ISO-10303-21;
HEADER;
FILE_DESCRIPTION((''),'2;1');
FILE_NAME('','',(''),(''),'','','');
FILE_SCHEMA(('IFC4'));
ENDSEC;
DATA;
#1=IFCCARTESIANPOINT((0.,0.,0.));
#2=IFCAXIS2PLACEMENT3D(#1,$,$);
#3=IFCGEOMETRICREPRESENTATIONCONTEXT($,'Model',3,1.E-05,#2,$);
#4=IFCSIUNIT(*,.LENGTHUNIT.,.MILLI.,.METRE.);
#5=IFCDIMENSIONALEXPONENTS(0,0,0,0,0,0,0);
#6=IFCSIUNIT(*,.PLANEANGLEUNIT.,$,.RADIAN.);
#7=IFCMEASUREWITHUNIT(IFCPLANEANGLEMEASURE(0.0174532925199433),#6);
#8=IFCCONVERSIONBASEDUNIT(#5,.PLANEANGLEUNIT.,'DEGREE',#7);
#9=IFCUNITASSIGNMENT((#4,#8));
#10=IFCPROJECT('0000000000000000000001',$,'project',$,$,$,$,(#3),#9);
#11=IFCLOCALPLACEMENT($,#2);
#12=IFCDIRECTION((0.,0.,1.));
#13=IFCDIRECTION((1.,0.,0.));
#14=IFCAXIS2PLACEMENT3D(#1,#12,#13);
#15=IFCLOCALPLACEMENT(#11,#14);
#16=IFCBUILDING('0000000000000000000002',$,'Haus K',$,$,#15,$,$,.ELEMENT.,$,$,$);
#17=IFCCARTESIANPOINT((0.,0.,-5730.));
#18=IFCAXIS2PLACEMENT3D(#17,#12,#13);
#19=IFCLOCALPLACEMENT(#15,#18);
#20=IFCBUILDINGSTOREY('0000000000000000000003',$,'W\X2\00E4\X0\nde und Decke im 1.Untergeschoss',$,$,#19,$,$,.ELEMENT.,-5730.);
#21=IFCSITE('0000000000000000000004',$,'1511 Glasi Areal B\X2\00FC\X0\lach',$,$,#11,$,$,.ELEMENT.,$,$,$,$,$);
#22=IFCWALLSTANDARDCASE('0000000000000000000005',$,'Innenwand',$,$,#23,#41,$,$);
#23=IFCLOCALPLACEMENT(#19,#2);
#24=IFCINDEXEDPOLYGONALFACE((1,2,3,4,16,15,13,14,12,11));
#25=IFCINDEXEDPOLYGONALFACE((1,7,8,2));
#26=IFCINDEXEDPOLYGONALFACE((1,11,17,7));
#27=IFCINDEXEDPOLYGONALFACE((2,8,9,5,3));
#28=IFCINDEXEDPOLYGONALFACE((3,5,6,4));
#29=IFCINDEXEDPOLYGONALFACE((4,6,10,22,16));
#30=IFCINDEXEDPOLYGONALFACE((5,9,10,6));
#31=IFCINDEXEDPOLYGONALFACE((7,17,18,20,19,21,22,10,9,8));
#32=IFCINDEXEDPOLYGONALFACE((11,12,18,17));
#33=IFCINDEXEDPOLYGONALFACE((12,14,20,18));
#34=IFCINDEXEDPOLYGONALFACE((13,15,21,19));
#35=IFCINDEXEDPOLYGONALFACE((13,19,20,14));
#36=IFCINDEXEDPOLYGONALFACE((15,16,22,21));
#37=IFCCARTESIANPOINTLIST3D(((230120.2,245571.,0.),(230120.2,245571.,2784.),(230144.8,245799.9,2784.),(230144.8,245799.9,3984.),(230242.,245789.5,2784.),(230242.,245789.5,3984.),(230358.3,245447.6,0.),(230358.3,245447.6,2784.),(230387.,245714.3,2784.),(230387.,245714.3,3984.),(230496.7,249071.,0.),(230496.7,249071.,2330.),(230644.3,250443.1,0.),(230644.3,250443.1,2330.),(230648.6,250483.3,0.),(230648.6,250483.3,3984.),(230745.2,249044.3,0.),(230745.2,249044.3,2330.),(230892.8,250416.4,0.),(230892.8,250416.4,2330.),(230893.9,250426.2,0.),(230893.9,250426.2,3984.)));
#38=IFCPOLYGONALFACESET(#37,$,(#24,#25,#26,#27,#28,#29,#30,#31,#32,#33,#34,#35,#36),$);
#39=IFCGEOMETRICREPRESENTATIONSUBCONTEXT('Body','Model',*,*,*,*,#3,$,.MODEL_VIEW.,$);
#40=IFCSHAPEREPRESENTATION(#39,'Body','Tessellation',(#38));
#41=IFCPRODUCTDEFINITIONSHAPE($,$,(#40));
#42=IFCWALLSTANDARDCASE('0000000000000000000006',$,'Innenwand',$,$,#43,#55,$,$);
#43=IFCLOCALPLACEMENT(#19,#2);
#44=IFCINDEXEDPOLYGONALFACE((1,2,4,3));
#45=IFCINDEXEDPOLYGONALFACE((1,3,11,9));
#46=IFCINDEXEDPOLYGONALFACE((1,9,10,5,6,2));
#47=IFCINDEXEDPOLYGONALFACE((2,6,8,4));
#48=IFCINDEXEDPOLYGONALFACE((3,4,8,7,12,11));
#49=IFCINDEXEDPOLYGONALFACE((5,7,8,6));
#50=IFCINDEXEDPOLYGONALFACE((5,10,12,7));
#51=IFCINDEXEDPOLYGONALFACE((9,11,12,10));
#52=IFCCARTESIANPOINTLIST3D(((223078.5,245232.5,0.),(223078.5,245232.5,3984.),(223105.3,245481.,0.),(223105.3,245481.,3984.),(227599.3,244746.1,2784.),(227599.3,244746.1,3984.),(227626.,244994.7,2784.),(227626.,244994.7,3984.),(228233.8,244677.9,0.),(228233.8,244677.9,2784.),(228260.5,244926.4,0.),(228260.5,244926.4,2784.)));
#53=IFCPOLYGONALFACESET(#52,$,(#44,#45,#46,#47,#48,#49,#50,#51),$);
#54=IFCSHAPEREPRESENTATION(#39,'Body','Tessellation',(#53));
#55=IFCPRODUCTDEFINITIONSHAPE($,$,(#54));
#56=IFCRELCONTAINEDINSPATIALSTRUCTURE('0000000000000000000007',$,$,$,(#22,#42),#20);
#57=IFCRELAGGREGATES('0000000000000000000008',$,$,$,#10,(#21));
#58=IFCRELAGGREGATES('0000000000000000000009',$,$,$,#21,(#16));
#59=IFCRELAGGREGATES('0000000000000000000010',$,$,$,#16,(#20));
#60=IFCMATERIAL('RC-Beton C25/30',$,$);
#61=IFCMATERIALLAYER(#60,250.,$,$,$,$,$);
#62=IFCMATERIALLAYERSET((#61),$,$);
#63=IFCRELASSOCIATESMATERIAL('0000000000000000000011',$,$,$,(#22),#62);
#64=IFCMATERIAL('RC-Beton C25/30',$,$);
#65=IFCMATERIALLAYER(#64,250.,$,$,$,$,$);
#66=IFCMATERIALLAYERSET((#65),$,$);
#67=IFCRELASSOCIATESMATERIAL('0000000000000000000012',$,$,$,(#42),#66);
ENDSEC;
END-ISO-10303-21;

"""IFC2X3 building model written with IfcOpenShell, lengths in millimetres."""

from ifc_helpers import new_model, entity, si_unit, converted_unit, frame, frame_2d, origin, origin_with_axes, place, context, subcontext, project, spatial, polyline, rectangle, outline, extrude, clip, bounded_halfspace, material, layer, layer_set, layer_usage, element, save


model = new_model("IFC2X3")

# Units and contexts
model_context = context("Model", 3, precision=1e-05, world=origin())
body_context = subcontext(model_context, "Body", "Model", "MODEL_VIEW")
ifc_project = project(units=[si_unit("LENGTHUNIT", "METRE", prefix="MILLI"), converted_unit("PLANEANGLEUNIT", "DEGREE", entity("IfcPlaneAngleMeasure", 0.0174532925199433), si_unit("PLANEANGLEUNIT", "RADIAN"), dimensions=[0, 0, 0, 0, 0, 0, 0])], contexts=[model_context])

# Site, building, storey
site_placement = place(None, origin())
site = spatial("IfcSite", under=ifc_project, at=site_placement, Name="1511 Glasi Areal Bülach", CompositionType="ELEMENT")
building_placement = place(site_placement, origin_with_axes())
building = spatial("IfcBuilding", under=site, at=building_placement, Name="Haus K", CompositionType="ELEMENT")
storey_placement = place(building_placement, frame((0.0, 0.0, -5730.0), z_axis=(0.0, 0.0, 1.0), x_axis=(1.0, 0.0, 0.0)))
storey = spatial("IfcBuildingStorey", under=building, at=storey_placement, Name="Wände und Decke im 1.Untergeschoss", CompositionType="ELEMENT", Elevation=-5730.0)

# Wall, opening
ifc_material_1 = material(Name="RC-Beton C25/30")
ifc_layer_1 = layer(ifc_material_1, 250.0)
ifc_layer_set_1 = layer_set([ifc_layer_1])
ifc_layer_usage_1 = layer_usage(ifc_layer_set_1, "AXIS2", "POSITIVE", 0.0)
wall_1_placement = place(storey_placement, frame((230648.6, 250483.3, 0.0), z_axis=(0.0, 0.0, 1.0), x_axis=(-0.106958, -0.994264, 0.0)))
wall_1 = element("IfcWallStandardCase", 1, at=wall_1_placement, inside=storey, material=ifc_layer_usage_1, Name="Innenwand", context=body_context, shape_type="Clipping", body=[
    clip(clip(extrude(outline(polyline([(0.0, 0.0), (4940.7, 0.0), (5037.9, 250.0), (4769.7, 250.0), (30.6, 250.0), (0.0, 0.0)])), origin_with_axes(), (0.0, 0.0, 1.0), 3984.0), bounded_halfspace(frame((4769.7, 250.0, 2784.0), z_axis=(0.0, 0.0, -1.0), x_axis=(-0.362601, -0.931945, 0.0)), True, origin(), polyline([(4769.7, 250.0), (4710.5, 97.8), (4710.5, 0.0), (4940.7, 0.0), (5037.9, 250.0), (4769.7, 250.0)]))), bounded_halfspace(frame((4710.5, 0.0, 3984.0), z_axis=(0.0, 0.0, -1.0), x_axis=(0.0, 1.0, 0.0)), True, origin(), polyline([(4710.5, 0.0), (4710.5, 97.8), (4769.7, 250.0), (30.6, 250.0), (0.0, 0.0), (4710.5, 0.0)]))),
])
opening_1_placement = place(wall_1_placement, frame((40.5, 0.0, 0.0), z_axis=(0.0, 1.0, 0.0), x_axis=(0.0, 0.0, 1.0)))
element("IfcOpeningElement", 2, at=opening_1_placement, cuts=wall_1, ObjectType="Opening", context=body_context, shape_type="SweptSolid", body=[
    extrude(rectangle(XDim=2330.0, YDim=1380.0, at=frame_2d((1165.0, 690.0), x_axis=(1.0, 0.0))), origin_with_axes(), (0.0, 0.0, 1.0), 250.0),
])

# Wall
ifc_material_2 = material(Name="RC-Beton C25/30")
ifc_layer_2 = layer(ifc_material_2, 250.0)
ifc_layer_set_2 = layer_set([ifc_layer_2])
ifc_layer_usage_2 = layer_usage(ifc_layer_set_2, "AXIS2", "POSITIVE", 0.0)
wall_2_placement = place(storey_placement, frame((228260.5, 244926.4, 0.0), z_axis=(0.0, 0.0, 1.0), x_axis=(-0.994264, 0.106958, 0.0)))
element("IfcWallStandardCase", 3, at=wall_2_placement, inside=storey, material=ifc_layer_usage_2, Name="Innenwand", context=body_context, shape_type="Clipping", body=[
    clip(clip(extrude(rectangle(XDim=5185.0, YDim=250.0, at=frame_2d((2592.5, 125.0), x_axis=(1.0, 0.0))), origin_with_axes(), (0.0, 0.0, 1.0), 3984.0), bounded_halfspace(frame((0.0, 0.0, 2784.0), z_axis=(0.0, 0.0, -1.0), x_axis=(1.0, 0.0, 0.0)), True, origin(), polyline([(0.0, 0.0), (638.2, 0.0), (638.2, 250.0), (0.0, 250.0), (0.0, 0.0)]))), bounded_halfspace(frame((638.2, 250.0, 3984.0), z_axis=(0.0, 0.0, -1.0), x_axis=(0.0, -1.0, 0.0)), True, origin(), polyline([(638.2, 250.0), (638.2, 0.0), (5185.0, 0.0), (5185.0, 250.0), (638.2, 250.0)]))),
])

save(model, "model.ifc")
